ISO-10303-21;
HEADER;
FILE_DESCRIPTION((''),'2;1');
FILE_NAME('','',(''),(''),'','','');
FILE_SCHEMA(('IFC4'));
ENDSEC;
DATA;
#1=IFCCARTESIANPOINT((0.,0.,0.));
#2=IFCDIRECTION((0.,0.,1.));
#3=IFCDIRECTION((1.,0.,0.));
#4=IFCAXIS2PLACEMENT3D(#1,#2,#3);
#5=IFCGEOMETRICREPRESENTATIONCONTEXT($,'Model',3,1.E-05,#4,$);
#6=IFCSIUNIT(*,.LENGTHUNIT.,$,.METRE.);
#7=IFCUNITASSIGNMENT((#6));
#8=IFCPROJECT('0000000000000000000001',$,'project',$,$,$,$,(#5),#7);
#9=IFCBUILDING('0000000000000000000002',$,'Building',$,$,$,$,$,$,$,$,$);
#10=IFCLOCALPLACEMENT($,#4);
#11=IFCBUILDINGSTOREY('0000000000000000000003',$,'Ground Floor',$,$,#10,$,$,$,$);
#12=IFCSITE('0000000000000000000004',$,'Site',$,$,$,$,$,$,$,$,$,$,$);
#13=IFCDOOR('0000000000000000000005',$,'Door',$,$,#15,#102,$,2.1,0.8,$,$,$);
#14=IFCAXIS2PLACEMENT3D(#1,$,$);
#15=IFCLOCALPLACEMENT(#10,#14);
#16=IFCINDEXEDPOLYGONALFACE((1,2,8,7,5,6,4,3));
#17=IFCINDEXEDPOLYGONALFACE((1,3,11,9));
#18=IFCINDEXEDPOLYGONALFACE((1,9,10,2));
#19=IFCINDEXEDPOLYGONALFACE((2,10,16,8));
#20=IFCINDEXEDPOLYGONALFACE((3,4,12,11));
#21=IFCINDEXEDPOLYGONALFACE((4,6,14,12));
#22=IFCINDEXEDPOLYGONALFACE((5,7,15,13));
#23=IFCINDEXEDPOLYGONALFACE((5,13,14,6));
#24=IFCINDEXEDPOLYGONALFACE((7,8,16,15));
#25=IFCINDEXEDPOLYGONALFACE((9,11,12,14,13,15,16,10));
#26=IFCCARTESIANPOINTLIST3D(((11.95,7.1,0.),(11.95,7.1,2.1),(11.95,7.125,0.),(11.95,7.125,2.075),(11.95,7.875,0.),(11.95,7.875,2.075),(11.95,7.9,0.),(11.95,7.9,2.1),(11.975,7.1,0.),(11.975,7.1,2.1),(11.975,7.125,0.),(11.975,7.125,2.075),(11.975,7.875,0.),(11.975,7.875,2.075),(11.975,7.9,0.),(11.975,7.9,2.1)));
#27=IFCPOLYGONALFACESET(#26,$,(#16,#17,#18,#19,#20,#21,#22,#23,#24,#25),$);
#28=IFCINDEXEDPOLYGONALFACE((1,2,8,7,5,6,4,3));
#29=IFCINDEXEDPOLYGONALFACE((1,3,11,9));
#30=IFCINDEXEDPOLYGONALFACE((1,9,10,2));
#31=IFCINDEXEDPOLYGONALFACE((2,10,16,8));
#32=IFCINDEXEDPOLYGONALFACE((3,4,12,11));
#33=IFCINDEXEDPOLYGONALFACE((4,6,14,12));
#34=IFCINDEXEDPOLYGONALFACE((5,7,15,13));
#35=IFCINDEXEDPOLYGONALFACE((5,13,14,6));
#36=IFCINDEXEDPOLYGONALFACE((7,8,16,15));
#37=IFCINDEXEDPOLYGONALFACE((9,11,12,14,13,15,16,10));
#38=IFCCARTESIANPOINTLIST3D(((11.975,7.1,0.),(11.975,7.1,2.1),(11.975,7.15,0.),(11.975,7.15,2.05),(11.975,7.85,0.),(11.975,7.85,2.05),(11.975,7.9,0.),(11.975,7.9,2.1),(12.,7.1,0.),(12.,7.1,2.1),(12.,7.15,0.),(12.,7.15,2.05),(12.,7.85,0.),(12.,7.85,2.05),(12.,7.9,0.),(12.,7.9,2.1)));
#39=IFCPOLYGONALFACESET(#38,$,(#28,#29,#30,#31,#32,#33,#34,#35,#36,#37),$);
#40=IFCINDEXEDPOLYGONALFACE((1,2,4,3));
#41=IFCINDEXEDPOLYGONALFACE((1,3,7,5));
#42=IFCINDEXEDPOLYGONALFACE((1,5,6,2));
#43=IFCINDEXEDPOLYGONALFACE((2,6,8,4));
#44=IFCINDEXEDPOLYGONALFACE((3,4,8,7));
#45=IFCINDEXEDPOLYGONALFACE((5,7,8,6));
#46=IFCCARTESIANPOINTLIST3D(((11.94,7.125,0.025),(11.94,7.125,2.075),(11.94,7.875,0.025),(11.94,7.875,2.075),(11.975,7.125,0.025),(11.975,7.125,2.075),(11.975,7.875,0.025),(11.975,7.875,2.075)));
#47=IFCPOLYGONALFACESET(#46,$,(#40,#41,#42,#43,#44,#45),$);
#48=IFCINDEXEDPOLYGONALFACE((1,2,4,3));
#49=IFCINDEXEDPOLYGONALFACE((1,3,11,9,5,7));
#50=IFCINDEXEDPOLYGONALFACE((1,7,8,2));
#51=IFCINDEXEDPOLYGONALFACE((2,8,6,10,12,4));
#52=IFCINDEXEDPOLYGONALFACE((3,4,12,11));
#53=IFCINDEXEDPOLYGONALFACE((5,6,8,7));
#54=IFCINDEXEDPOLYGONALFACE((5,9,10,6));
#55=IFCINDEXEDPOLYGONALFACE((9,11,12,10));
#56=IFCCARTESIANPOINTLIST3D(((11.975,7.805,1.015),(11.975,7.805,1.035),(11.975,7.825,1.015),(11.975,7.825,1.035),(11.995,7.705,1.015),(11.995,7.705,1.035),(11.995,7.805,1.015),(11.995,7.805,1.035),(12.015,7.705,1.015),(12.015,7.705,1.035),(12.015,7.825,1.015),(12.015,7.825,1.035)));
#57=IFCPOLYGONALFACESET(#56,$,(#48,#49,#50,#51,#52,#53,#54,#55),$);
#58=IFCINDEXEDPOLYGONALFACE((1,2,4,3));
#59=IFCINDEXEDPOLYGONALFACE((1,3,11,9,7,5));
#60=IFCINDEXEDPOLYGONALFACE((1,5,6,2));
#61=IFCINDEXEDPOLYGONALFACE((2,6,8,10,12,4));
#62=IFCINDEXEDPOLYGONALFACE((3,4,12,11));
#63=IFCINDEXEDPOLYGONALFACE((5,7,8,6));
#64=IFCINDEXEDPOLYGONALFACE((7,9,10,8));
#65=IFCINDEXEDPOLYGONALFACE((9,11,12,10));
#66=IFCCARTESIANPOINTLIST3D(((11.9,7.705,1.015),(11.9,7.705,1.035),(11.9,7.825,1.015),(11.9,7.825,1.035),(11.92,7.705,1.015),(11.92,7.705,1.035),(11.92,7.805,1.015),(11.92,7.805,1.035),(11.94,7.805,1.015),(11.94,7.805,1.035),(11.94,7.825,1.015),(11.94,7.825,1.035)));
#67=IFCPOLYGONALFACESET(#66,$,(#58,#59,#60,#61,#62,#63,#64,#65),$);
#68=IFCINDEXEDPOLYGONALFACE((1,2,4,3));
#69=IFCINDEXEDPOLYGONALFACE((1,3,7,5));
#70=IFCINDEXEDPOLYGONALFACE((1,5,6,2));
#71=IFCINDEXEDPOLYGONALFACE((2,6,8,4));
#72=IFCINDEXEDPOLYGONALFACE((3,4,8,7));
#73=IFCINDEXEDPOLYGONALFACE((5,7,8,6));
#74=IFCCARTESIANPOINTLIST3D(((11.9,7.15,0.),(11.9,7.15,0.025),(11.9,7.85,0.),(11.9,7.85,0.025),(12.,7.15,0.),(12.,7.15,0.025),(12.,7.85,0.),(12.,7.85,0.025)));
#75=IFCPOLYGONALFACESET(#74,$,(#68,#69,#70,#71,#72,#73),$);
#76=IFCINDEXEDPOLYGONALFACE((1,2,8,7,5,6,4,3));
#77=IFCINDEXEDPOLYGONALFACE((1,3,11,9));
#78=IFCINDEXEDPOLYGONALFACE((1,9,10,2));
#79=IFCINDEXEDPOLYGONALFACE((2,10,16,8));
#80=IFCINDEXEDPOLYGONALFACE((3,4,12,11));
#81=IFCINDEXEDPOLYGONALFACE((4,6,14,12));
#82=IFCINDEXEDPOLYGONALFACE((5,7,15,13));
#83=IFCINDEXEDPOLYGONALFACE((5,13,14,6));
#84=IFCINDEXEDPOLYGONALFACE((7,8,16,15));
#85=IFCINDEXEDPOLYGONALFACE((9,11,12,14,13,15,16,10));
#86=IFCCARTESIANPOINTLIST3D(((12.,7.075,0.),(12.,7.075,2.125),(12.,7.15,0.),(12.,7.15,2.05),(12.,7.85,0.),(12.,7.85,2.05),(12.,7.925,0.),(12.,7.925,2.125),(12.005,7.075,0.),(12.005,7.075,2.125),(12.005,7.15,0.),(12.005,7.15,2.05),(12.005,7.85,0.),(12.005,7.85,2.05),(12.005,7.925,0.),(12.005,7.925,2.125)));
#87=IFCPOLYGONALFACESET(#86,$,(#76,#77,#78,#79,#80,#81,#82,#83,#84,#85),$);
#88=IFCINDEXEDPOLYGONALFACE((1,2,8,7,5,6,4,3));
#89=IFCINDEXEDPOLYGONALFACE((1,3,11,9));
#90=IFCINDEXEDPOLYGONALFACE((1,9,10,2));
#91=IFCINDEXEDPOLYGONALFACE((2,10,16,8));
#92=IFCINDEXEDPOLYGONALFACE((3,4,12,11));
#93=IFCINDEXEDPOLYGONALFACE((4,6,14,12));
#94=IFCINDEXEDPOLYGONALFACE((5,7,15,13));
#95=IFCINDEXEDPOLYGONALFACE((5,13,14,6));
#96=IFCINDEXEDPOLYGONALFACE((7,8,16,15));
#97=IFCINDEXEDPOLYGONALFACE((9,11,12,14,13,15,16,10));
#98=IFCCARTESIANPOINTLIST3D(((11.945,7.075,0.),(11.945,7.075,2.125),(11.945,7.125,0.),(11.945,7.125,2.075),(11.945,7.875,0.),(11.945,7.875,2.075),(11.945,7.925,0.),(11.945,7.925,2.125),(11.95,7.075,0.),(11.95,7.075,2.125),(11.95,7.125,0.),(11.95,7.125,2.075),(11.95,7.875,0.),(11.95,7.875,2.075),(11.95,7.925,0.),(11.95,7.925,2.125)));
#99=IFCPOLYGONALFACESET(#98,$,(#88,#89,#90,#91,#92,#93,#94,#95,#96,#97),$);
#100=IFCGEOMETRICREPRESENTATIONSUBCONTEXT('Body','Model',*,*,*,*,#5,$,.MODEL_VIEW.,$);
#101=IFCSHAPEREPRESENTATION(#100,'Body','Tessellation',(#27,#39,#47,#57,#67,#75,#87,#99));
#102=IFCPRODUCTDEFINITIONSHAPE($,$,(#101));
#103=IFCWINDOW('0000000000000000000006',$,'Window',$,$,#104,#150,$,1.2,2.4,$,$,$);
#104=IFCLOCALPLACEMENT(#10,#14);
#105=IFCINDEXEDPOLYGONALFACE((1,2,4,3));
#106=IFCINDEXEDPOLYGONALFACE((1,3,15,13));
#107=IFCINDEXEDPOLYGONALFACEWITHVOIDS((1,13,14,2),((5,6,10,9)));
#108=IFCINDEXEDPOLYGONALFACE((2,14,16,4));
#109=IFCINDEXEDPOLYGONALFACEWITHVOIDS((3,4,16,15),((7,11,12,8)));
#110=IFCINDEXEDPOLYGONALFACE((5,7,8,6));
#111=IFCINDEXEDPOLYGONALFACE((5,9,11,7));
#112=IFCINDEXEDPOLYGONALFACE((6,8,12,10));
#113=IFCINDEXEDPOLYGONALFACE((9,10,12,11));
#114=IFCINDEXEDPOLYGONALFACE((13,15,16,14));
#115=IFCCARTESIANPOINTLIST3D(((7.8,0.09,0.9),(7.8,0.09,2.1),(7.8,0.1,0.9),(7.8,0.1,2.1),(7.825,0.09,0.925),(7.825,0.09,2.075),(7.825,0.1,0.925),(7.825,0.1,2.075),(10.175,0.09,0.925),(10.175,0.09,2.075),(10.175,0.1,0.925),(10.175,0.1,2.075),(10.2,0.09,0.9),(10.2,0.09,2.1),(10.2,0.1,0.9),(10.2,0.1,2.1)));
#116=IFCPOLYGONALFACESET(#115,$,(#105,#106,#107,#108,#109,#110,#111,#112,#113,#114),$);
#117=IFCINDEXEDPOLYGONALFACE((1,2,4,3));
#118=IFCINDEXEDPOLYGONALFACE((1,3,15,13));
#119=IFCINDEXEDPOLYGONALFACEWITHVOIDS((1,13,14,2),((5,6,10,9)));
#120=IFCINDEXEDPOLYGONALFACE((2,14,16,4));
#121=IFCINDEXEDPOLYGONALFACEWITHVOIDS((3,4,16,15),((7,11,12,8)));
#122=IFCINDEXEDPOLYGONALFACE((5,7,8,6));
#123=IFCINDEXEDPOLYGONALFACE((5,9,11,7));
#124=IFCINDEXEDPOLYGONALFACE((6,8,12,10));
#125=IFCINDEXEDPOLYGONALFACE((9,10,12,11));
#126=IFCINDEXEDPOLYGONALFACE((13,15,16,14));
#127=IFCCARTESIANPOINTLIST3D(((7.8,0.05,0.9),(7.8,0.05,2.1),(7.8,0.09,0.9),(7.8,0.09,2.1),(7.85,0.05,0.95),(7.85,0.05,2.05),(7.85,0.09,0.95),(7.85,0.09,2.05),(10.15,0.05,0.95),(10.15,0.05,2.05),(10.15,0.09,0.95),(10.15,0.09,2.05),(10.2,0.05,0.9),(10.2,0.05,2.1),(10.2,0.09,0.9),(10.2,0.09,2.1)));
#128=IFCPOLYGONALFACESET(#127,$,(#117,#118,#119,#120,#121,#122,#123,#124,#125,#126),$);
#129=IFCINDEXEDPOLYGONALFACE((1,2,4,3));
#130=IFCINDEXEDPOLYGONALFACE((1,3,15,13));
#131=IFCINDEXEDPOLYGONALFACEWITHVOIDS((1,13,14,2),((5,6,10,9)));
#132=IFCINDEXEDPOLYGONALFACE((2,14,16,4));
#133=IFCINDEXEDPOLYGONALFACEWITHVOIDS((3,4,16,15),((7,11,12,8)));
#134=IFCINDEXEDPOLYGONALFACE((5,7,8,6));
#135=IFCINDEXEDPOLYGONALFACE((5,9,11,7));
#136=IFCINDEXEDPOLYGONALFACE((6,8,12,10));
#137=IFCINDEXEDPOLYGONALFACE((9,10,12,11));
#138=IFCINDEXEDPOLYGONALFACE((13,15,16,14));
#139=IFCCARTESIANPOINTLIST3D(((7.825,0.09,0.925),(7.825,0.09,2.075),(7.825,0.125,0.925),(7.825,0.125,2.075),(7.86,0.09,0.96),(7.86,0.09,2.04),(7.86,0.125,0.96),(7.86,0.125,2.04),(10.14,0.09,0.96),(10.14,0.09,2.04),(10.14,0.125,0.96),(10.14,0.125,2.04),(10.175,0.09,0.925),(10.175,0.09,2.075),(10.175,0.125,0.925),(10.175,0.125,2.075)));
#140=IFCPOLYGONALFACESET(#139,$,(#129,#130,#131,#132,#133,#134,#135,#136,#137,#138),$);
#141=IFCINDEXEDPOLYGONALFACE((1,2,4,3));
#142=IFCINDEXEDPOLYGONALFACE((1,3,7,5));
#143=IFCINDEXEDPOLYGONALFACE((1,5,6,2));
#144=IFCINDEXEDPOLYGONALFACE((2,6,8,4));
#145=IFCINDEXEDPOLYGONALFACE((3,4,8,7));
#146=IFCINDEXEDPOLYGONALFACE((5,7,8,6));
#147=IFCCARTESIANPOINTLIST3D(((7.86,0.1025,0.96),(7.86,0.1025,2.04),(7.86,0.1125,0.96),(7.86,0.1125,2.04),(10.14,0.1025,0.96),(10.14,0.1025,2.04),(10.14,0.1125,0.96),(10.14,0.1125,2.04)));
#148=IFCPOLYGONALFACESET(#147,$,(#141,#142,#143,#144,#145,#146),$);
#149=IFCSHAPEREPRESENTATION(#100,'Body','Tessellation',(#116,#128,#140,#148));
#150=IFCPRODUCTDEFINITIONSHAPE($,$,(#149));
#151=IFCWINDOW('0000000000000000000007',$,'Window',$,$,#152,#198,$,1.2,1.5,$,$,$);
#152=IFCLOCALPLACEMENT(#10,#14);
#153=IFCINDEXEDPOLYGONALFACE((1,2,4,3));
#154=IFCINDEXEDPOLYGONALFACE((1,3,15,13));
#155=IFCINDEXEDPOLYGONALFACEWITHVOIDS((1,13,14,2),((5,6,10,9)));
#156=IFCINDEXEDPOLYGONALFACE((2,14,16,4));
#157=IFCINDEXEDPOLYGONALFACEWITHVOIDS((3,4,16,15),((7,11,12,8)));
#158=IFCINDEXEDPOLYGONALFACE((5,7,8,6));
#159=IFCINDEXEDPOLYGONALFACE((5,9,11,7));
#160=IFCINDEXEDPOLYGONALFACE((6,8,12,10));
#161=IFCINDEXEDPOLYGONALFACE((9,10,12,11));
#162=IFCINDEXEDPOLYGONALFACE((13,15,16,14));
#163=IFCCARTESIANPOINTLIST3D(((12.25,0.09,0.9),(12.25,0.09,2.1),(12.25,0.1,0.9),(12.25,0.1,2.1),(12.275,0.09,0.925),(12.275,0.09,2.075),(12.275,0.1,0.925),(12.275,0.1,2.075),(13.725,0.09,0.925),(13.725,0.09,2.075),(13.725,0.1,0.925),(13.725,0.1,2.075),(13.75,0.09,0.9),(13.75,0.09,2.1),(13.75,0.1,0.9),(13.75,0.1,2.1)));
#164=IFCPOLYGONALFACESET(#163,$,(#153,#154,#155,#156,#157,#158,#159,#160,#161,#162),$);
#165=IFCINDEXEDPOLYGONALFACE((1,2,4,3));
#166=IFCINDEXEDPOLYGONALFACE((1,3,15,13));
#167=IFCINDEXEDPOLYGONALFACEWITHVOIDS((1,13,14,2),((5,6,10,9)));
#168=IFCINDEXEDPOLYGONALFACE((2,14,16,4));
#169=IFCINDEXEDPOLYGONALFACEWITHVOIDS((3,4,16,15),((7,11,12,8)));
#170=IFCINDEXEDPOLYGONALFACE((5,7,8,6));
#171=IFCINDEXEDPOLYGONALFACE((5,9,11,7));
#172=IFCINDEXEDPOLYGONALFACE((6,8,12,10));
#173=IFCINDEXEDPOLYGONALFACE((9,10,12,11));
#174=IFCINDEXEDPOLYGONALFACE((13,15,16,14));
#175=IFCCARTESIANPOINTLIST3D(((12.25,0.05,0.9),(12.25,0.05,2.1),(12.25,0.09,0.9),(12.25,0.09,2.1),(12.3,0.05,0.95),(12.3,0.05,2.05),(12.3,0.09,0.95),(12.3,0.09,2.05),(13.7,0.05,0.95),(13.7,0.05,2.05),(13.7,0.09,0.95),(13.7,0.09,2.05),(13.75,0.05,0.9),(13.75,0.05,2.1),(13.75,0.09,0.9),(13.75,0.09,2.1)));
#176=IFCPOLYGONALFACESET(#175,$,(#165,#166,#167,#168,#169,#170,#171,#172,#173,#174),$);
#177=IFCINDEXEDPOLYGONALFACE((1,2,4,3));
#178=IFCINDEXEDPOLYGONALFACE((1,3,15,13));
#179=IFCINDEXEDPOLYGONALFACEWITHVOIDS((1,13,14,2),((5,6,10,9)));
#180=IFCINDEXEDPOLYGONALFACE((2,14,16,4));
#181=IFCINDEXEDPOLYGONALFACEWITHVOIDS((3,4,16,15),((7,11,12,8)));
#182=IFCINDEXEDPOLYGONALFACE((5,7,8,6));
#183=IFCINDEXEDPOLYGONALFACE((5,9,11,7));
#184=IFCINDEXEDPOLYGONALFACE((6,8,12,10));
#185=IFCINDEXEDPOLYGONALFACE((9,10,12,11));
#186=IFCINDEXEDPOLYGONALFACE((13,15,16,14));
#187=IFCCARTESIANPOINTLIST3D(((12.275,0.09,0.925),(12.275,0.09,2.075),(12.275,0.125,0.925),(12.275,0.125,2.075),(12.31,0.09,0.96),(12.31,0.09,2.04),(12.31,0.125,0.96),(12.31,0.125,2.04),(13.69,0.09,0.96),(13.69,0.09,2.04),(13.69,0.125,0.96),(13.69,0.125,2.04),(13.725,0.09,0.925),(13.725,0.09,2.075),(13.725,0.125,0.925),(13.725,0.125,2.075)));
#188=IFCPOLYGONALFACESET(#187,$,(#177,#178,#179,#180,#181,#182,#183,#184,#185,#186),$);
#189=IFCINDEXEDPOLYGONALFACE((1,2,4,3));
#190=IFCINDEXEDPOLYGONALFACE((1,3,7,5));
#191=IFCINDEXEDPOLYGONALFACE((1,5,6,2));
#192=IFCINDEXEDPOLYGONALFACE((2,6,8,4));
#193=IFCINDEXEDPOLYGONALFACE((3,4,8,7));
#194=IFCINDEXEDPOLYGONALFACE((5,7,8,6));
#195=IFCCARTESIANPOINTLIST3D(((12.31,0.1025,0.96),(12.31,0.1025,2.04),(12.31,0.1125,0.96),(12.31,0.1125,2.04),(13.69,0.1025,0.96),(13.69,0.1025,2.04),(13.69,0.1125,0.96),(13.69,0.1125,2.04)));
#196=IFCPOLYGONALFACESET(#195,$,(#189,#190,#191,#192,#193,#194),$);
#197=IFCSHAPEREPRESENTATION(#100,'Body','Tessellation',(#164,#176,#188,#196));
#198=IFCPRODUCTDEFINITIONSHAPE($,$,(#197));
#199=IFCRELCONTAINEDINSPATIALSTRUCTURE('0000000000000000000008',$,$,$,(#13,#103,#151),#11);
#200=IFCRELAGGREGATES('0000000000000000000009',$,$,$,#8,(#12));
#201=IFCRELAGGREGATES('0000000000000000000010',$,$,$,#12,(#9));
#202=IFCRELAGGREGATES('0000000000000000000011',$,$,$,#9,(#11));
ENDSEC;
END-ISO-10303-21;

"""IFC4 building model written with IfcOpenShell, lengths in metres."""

from ifc_helpers import new_model, si_unit, frame, origin_with_axes, place, context, subcontext, project, spatial, line, indexed_curve, outline, extrude, element, save


model = new_model("IFC4")

# Units and contexts
model_context = context("Model", 3, precision=1e-05, world=origin_with_axes())
body_context = subcontext(model_context, "Body", "Model", "MODEL_VIEW")
ifc_project = project(units=[si_unit("LENGTHUNIT", "METRE")], contexts=[model_context])

# Site, building, storey
site = spatial("IfcSite", under=ifc_project, Name="Site")
building = spatial("IfcBuilding", under=site, Name="Building")
storey_placement = place(None, origin_with_axes())
storey = spatial("IfcBuildingStorey", under=building, at=storey_placement, Name="Ground Floor")

# Door
door_1_placement = place(storey_placement, frame((12.0, 7.1, 0.0), z_axis=(0.0, 0.0, 1.0), x_axis=(0.0, 1.0, 0.0)))
element("IfcDoor", 1, at=door_1_placement, inside=storey, Name="Door", OverallHeight=2.1, OverallWidth=0.8, context=body_context, shape_type="SweptSolid", body=[
    extrude(outline(indexed_curve([(0.0, 0.0), (0.0, 2.1), (0.8, 2.1), (0.8, 0.0), (0.775, 0.0), (0.775, 2.075), (0.025, 2.075), (0.025, 0.0)], segments=[line(1, 2, 3, 4, 5, 6, 7, 8, 1)])), frame((0.0, 0.025, 0.0), z_axis=(0.0, -1.0, 0.0), x_axis=(1.0, 0.0, 0.0)), (0.0, 0.0, -1.0), 0.025),
    extrude(outline(indexed_curve([(0.0, 0.0), (0.0, 2.1), (0.8, 2.1), (0.8, 0.0), (0.75, 0.0), (0.75, 2.05), (0.05, 2.05), (0.05, 0.0)], segments=[line(1, 2, 3, 4, 5, 6, 7, 8, 1)])), frame((0.0, 0.0, 0.0), z_axis=(0.0, -1.0, 0.0), x_axis=(1.0, 0.0, 0.0)), (0.0, 0.0, -1.0), 0.025),
    extrude(outline(indexed_curve([(0.0, 0.0), (0.75, 0.0), (0.75, 0.035), (0.0, 0.035)], segments=[line(1, 2, 3, 4, 1)])), frame((0.025, 0.025, 0.025), z_axis=(0.0, 0.0, 1.0), x_axis=(1.0, 0.0, 0.0)), (0.0, 0.0, 1.0), 2.05),
    extrude(outline(indexed_curve([(0.0, 0.0), (0.0, -0.04), (-0.12, -0.04), (-0.12, -0.02), (-0.02, -0.02), (-0.02, 0.0)], segments=[line(1, 2, 3, 4, 5, 6, 1)])), frame((0.725, 0.025, 1.015), z_axis=(0.0, 0.0, 1.0), x_axis=(1.0, 0.0, 0.0)), (0.0, 0.0, 1.0), 0.02),
    extrude(outline(indexed_curve([(0.0, 0.0), (0.0, 0.04), (-0.12, 0.04), (-0.12, 0.02), (-0.02, 0.02), (-0.02, 0.0)], segments=[line(1, 2, 3, 4, 5, 6, 1)])), frame((0.725, 0.06, 1.015), z_axis=(0.0, 0.0, 1.0), x_axis=(1.0, 0.0, 0.0)), (0.0, 0.0, 1.0), 0.02),
    extrude(outline(indexed_curve([(0.0, 0.0), (0.7, 0.0), (0.7, 0.1), (0.0, 0.1)], segments=[line(1, 2, 3, 4, 1)])), frame((0.05, 0.0, 0.0), z_axis=(0.0, 0.0, 1.0), x_axis=(1.0, 0.0, 0.0)), (0.0, 0.0, 1.0), 0.025),
    extrude(outline(indexed_curve([(0.0, 0.0), (0.0, 2.125), (0.85, 2.125), (0.85, 0.0), (0.775, 0.0), (0.775, 2.05), (0.075, 2.05), (0.075, 0.0)], segments=[line(1, 2, 3, 4, 5, 6, 7, 8, 1)])), frame((-0.025, -0.005, 0.0), z_axis=(0.0, -1.0, 0.0), x_axis=(1.0, 0.0, 0.0)), (0.0, 0.0, -1.0), 0.005),
    extrude(outline(indexed_curve([(0.0, 0.0), (0.0, 2.125), (0.85, 2.125), (0.85, 0.0), (0.8, 0.0), (0.8, 2.075), (0.05, 2.075), (0.05, 0.0)], segments=[line(1, 2, 3, 4, 5, 6, 7, 8, 1)])), frame((-0.025, 0.05, 0.0), z_axis=(0.0, -1.0, 0.0), x_axis=(1.0, 0.0, 0.0)), (0.0, 0.0, -1.0), 0.005),
])

# Windows
window_1_placement = place(storey_placement, frame((7.8, 0.0, 0.9), z_axis=(0.0, 0.0, 1.0), x_axis=(1.0, 0.0, 0.0)))
element("IfcWindow", 2, at=window_1_placement, inside=storey, Name="Window", OverallHeight=1.2, OverallWidth=2.4, context=body_context, shape_type="SweptSolid", body=[
    extrude(outline(indexed_curve([(0.0, 0.0), (2.4, 0.0), (2.4, 1.2), (0.0, 1.2)], segments=[line(1, 2, 3, 4, 1)]), holes=[indexed_curve([(0.025, 0.025), (2.375, 0.025), (2.375, 1.175), (0.025, 1.175)], segments=[line(1, 2, 3, 4, 1)])]), frame((0.0, 0.09, 0.0), z_axis=(0.0, -1.0, 0.0), x_axis=(1.0, 0.0, 0.0)), (0.0, 0.0, -1.0), 0.01),
    extrude(outline(indexed_curve([(0.0, 0.0), (2.4, 0.0), (2.4, 1.2), (0.0, 1.2)], segments=[line(1, 2, 3, 4, 1)]), holes=[indexed_curve([(0.05, 0.05), (2.35, 0.05), (2.35, 1.15), (0.05, 1.15)], segments=[line(1, 2, 3, 4, 1)])]), frame((0.0, 0.05, 0.0), z_axis=(0.0, -1.0, 0.0), x_axis=(1.0, 0.0, 0.0)), (0.0, 0.0, -1.0), 0.04),
    extrude(outline(indexed_curve([(0.0, 0.0), (2.35, 0.0), (2.35, 1.15), (0.0, 1.15)], segments=[line(1, 2, 3, 4, 1)]), holes=[indexed_curve([(0.035, 0.035), (2.315, 0.035), (2.315, 1.115), (0.035, 1.115)], segments=[line(1, 2, 3, 4, 1)])]), frame((0.025, 0.09, 0.025), z_axis=(0.0, -1.0, 0.0), x_axis=(1.0, 0.0, 0.0)), (0.0, 0.0, -1.0), 0.035),
    extrude(outline(indexed_curve([(0.035, 0.035), (2.315, 0.035), (2.315, 1.115), (0.035, 1.115)], segments=[line(1, 2, 3, 4, 1)])), frame((0.025, 0.1025, 0.025), z_axis=(0.0, -1.0, 0.0), x_axis=(1.0, 0.0, 0.0)), (0.0, 0.0, -1.0), 0.01),
])
for number, where, z_axis, x_axis, name in (
    (3, (12.25, 0.0, 0.9), (0.0, 0.0, 1.0), (1.0, 0.0, 0.0), "Window"),
):
    element("IfcWindow", number, at=place(storey_placement, frame(where, z_axis=z_axis, x_axis=x_axis)), inside=storey, Name=name, OverallHeight=1.2, OverallWidth=1.5, context=body_context, shape_type="SweptSolid", body=[
        extrude(outline(indexed_curve([(0.0, 0.0), (1.5, 0.0), (1.5, 1.2), (0.0, 1.2)], segments=[line(1, 2, 3, 4, 1)]), holes=[indexed_curve([(0.025, 0.025), (1.475, 0.025), (1.475, 1.175), (0.025, 1.175)], segments=[line(1, 2, 3, 4, 1)])]), frame((0.0, 0.09, 0.0), z_axis=(0.0, -1.0, 0.0), x_axis=(1.0, 0.0, 0.0)), (0.0, 0.0, -1.0), 0.01),
        extrude(outline(indexed_curve([(0.0, 0.0), (1.5, 0.0), (1.5, 1.2), (0.0, 1.2)], segments=[line(1, 2, 3, 4, 1)]), holes=[indexed_curve([(0.05, 0.05), (1.45, 0.05), (1.45, 1.15), (0.05, 1.15)], segments=[line(1, 2, 3, 4, 1)])]), frame((0.0, 0.05, 0.0), z_axis=(0.0, -1.0, 0.0), x_axis=(1.0, 0.0, 0.0)), (0.0, 0.0, -1.0), 0.04),
        extrude(outline(indexed_curve([(0.0, 0.0), (1.45, 0.0), (1.45, 1.15), (0.0, 1.15)], segments=[line(1, 2, 3, 4, 1)]), holes=[indexed_curve([(0.035, 0.035), (1.415, 0.035), (1.415, 1.115), (0.035, 1.115)], segments=[line(1, 2, 3, 4, 1)])]), frame((0.025, 0.09, 0.025), z_axis=(0.0, -1.0, 0.0), x_axis=(1.0, 0.0, 0.0)), (0.0, 0.0, -1.0), 0.035),
        extrude(outline(indexed_curve([(0.035, 0.035), (1.415, 0.035), (1.415, 1.115), (0.035, 1.115)], segments=[line(1, 2, 3, 4, 1)])), frame((0.025, 0.1025, 0.025), z_axis=(0.0, -1.0, 0.0), x_axis=(1.0, 0.0, 0.0)), (0.0, 0.0, -1.0), 0.01),
    ])

save(model, "model.ifc")
